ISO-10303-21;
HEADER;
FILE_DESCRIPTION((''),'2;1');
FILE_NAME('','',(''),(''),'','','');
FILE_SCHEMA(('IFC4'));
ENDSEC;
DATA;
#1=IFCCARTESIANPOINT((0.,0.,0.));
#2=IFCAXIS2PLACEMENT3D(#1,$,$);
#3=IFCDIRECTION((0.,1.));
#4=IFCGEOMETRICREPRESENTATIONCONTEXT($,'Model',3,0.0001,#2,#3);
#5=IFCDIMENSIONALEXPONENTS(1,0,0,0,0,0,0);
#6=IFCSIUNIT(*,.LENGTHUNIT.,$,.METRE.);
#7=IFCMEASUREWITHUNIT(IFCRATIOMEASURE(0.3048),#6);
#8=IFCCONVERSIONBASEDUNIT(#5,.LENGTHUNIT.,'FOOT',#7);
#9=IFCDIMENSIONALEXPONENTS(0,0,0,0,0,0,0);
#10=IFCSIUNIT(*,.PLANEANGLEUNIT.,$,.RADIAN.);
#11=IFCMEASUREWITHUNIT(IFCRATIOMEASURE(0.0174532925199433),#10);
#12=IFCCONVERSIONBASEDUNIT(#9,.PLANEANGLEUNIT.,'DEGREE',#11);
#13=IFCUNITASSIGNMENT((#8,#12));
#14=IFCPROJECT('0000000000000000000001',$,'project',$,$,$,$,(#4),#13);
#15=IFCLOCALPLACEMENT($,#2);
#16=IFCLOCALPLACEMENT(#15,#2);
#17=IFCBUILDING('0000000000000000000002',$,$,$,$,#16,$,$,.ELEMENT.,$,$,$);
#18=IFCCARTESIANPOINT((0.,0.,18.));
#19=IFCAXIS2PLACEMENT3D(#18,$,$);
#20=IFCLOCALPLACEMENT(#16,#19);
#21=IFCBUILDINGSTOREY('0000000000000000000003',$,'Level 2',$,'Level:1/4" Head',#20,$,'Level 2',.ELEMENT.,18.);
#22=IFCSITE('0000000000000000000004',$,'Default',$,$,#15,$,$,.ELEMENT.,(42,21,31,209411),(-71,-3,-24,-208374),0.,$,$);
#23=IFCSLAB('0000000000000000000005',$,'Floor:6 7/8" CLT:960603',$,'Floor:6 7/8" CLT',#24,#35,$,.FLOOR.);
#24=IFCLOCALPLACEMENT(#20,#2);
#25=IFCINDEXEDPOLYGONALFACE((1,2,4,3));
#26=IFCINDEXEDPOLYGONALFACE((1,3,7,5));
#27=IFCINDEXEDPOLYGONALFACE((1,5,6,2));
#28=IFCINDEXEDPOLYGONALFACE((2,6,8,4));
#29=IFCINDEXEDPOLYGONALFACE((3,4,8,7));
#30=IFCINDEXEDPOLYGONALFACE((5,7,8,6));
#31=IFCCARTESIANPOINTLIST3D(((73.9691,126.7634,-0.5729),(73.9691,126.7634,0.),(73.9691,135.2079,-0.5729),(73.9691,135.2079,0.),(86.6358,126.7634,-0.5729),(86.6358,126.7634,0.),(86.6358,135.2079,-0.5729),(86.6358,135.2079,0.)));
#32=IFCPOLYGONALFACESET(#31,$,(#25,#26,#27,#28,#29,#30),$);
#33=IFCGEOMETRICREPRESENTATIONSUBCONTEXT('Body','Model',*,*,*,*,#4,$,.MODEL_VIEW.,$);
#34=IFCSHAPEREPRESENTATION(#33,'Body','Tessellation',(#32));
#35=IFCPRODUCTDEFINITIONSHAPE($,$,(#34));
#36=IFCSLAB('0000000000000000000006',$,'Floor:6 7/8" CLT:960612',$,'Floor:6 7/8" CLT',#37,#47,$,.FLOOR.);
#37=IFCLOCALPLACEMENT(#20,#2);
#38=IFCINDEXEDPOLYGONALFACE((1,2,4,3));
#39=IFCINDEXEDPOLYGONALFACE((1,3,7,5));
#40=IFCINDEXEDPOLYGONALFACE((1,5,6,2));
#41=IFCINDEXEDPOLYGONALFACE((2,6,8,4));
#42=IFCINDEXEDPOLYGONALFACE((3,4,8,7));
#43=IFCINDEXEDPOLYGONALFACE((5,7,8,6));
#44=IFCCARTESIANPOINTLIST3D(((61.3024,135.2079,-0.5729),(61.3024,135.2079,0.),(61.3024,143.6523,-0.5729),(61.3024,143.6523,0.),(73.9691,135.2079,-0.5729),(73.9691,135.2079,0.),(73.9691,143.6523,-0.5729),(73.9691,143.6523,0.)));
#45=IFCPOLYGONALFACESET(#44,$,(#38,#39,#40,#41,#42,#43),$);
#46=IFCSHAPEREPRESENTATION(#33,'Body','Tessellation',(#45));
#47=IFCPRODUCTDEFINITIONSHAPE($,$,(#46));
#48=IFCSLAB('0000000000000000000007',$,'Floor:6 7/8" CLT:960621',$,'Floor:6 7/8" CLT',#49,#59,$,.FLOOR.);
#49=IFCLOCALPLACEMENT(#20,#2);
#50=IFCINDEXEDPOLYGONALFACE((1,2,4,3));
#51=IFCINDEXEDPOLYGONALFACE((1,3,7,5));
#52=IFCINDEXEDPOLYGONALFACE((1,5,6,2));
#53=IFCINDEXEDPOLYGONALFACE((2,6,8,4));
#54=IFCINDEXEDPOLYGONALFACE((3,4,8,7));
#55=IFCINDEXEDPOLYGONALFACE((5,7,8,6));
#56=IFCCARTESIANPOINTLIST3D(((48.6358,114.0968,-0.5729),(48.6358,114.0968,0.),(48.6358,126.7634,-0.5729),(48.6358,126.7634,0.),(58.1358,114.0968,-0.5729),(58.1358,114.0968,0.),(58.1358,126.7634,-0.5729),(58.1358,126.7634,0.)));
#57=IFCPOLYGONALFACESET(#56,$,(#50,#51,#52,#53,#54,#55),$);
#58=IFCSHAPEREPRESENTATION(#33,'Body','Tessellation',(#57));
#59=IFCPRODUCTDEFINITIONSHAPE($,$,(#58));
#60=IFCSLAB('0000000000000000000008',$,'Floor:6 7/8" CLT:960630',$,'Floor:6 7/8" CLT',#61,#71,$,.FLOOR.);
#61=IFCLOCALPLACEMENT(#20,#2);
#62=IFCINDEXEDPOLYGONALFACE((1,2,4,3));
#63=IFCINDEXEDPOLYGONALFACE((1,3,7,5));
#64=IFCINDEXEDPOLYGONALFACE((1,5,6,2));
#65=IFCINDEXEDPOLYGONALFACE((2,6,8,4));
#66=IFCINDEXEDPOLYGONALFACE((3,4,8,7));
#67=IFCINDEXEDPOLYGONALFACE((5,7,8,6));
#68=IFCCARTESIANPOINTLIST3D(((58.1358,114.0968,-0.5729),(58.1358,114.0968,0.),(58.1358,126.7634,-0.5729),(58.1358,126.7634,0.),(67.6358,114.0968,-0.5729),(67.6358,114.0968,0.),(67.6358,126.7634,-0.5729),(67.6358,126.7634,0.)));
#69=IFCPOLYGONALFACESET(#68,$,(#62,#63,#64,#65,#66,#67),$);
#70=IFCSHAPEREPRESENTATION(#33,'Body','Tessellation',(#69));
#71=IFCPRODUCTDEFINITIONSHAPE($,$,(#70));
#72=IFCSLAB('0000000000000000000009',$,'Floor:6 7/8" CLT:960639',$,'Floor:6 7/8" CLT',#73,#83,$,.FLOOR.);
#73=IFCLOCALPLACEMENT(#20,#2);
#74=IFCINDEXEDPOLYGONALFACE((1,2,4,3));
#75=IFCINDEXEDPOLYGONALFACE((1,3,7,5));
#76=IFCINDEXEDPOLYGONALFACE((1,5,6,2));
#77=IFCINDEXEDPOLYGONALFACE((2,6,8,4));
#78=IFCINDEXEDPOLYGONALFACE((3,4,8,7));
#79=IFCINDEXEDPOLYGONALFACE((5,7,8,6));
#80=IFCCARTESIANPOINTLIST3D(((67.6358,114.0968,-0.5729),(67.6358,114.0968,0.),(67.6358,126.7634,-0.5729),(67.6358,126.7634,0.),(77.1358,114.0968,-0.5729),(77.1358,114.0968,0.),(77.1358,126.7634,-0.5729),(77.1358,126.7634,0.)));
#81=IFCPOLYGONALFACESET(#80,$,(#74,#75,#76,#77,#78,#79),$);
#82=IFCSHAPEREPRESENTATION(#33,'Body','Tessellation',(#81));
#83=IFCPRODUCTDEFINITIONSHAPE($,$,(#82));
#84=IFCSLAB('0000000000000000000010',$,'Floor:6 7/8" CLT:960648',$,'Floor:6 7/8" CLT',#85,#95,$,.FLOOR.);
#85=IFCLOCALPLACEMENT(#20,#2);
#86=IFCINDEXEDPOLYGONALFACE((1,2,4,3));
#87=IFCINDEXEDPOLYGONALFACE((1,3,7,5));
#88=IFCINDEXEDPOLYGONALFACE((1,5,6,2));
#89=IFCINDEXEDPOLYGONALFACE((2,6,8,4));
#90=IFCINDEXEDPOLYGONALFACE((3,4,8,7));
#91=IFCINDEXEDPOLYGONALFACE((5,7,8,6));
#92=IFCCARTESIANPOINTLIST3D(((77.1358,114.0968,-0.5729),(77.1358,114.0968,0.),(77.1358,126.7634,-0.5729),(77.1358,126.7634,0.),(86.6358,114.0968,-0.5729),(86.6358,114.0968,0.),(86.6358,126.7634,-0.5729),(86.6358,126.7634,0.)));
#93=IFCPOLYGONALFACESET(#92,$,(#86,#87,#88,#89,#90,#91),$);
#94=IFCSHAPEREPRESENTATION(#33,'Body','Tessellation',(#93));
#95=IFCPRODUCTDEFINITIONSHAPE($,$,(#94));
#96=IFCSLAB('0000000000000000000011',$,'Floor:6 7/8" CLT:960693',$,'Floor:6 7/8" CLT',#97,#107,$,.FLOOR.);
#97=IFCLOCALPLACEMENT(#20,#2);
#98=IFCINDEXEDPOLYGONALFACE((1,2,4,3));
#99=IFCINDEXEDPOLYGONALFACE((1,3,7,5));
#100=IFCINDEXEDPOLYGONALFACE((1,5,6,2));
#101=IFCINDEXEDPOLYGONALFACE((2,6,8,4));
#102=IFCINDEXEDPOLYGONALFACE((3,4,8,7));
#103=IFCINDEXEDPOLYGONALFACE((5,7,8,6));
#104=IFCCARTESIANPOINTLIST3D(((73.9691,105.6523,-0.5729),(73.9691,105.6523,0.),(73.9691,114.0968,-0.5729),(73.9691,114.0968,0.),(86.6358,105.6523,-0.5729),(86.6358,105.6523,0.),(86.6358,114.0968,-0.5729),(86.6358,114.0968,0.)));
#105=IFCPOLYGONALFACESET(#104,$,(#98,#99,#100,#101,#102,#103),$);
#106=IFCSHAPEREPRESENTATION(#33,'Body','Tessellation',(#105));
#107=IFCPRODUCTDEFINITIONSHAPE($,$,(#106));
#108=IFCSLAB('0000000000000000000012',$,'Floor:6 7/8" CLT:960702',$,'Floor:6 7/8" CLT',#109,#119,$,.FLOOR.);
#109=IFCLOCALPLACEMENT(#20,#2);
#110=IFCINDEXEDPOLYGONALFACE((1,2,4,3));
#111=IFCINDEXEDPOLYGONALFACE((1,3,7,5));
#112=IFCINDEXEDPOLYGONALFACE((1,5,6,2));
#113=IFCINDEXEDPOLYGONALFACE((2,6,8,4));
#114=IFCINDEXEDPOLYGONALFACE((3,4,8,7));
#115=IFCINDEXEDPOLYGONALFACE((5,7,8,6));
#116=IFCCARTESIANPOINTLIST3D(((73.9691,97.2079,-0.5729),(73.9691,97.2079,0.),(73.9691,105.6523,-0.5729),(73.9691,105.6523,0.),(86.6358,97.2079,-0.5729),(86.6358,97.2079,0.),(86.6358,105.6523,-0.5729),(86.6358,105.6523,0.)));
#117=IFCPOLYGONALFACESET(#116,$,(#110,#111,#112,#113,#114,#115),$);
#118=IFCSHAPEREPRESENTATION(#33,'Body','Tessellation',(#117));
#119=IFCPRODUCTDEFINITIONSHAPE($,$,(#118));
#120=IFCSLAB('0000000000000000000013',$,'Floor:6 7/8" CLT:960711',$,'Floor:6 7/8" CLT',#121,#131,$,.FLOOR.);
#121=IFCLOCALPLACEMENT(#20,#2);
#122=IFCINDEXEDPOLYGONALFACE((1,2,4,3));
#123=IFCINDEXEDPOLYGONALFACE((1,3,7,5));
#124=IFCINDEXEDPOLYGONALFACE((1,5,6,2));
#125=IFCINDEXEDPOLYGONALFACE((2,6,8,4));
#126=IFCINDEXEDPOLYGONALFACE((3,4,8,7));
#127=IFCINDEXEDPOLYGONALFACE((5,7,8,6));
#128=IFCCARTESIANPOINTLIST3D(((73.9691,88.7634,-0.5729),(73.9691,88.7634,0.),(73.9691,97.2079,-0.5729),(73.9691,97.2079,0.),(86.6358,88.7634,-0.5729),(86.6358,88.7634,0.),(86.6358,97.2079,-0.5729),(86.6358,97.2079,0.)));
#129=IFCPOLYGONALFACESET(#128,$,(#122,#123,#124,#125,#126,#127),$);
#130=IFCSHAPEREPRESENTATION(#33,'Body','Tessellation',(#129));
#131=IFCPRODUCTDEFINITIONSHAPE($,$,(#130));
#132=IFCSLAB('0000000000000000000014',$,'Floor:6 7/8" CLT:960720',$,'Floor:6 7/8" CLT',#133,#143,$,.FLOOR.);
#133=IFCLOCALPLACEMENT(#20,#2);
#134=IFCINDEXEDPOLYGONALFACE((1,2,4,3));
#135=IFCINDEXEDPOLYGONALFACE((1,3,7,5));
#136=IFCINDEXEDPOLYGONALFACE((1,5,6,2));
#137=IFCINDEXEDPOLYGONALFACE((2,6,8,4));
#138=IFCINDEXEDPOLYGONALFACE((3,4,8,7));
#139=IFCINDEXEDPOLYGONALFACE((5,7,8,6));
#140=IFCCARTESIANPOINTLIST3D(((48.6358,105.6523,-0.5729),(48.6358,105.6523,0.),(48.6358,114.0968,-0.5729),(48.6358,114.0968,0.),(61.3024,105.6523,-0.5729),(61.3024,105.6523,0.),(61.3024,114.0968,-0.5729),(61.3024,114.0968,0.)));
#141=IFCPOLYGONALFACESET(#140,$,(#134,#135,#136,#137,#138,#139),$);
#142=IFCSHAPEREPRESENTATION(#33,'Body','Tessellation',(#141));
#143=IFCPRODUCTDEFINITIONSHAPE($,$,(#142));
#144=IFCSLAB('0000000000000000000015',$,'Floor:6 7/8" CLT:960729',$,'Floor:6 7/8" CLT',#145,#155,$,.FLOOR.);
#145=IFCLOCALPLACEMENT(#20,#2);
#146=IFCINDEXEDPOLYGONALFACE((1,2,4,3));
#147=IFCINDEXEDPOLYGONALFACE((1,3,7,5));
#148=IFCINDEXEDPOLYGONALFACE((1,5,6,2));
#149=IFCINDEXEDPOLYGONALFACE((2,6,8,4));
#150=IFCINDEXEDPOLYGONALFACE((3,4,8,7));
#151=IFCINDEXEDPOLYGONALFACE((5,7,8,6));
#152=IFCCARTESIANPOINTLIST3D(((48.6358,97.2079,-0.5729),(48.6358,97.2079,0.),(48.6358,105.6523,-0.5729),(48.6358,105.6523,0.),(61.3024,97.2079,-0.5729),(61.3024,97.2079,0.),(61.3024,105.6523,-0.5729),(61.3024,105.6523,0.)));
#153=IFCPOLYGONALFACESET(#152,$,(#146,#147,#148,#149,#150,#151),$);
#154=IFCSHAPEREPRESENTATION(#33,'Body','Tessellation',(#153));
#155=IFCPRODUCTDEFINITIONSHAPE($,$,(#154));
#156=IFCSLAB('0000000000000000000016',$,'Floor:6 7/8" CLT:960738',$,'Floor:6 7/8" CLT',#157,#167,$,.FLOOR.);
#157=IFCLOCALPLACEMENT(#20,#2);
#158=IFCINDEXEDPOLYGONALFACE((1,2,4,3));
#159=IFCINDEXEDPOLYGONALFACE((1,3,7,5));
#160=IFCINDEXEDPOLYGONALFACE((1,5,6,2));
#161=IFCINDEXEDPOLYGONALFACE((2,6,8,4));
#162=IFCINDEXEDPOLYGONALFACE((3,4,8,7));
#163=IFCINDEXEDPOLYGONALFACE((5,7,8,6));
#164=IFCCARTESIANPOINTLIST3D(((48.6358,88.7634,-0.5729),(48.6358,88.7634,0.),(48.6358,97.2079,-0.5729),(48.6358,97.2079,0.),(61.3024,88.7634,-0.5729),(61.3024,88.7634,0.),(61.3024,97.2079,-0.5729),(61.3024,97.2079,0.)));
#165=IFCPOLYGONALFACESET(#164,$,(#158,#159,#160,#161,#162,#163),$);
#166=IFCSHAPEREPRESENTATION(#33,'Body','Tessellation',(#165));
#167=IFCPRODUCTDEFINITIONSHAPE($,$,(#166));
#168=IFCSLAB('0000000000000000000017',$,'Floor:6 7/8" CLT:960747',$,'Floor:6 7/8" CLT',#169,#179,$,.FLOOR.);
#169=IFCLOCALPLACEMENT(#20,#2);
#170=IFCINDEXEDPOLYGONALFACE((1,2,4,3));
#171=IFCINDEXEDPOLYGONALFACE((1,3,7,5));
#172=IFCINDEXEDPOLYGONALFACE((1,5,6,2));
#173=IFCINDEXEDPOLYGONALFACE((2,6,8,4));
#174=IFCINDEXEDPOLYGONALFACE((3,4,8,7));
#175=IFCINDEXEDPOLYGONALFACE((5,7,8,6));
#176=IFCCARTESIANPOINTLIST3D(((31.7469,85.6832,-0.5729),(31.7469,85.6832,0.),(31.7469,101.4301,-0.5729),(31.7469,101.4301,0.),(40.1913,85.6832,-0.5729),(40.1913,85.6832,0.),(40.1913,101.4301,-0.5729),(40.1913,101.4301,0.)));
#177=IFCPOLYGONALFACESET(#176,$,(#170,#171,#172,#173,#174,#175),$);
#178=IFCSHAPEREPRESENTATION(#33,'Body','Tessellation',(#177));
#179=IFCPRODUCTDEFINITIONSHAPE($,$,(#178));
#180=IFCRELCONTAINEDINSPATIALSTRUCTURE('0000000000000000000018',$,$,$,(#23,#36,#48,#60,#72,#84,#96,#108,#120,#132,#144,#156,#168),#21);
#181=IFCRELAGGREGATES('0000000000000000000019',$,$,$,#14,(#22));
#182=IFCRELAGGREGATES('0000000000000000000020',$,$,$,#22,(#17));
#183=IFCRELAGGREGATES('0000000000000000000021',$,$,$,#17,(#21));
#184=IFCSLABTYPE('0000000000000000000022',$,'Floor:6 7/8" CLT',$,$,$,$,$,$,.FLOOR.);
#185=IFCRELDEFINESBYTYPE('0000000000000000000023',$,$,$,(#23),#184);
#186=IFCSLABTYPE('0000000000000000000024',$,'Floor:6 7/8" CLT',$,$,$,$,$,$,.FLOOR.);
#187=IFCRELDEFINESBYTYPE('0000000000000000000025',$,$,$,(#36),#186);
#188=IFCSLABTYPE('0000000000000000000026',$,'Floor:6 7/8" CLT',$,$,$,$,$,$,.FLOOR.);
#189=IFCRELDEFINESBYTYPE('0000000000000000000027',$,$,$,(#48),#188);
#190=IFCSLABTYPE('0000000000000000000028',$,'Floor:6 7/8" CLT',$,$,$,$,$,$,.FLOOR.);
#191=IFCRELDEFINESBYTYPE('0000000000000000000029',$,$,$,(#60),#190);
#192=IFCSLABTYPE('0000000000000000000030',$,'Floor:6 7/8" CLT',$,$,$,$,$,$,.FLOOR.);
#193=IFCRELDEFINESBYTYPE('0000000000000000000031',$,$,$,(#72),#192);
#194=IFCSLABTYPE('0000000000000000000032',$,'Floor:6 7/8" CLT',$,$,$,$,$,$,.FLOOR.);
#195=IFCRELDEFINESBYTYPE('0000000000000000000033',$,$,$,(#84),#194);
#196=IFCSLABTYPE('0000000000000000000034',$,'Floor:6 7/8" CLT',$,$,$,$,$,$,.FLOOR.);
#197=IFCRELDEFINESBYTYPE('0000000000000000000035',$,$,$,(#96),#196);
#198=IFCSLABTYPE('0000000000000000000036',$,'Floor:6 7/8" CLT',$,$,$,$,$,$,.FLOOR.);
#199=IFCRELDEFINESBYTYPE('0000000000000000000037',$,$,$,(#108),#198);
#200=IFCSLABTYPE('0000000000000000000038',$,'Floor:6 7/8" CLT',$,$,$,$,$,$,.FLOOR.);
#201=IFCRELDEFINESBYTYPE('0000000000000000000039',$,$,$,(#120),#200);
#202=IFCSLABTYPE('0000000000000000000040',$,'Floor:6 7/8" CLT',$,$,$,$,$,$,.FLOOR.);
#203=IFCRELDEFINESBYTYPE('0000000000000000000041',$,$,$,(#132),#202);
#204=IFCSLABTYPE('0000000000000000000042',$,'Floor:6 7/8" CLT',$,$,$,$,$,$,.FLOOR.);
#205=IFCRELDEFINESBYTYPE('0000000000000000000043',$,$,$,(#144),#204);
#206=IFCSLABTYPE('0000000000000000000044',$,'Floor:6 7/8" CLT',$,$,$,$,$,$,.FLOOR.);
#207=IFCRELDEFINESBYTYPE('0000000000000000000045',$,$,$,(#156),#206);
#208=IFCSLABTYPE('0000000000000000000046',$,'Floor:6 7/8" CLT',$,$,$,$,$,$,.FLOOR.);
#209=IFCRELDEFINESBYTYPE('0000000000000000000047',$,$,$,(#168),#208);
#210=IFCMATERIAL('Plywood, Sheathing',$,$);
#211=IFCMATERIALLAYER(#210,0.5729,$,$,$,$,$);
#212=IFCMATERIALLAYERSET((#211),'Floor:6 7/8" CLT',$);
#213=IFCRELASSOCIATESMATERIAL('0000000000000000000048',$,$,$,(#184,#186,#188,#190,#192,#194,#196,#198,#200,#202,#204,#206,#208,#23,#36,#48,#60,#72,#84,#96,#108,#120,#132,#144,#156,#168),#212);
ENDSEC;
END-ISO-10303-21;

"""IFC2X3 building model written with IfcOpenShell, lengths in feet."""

from ifc_helpers import new_model, entity, si_unit, converted_unit, direction, frame, frame_2d, origin, place, context, subcontext, project, spatial, rectangle, extrude, material, layer, layer_set, layer_usage, type_object, element, save


model = new_model("IFC2X3")

# Units and contexts
model_context = context("Model", 3, precision=0.0001, world=origin(), true_north=direction((0.0, 1.0)))
body_context = subcontext(model_context, "Body", "Model", "MODEL_VIEW")
ifc_project = project(units=[converted_unit("LENGTHUNIT", "FOOT", entity("IfcRatioMeasure", 0.3048), si_unit("LENGTHUNIT", "METRE"), dimensions=[1, 0, 0, 0, 0, 0, 0]), converted_unit("PLANEANGLEUNIT", "DEGREE", entity("IfcRatioMeasure", 0.0174532925199433), si_unit("PLANEANGLEUNIT", "RADIAN"), dimensions=[0, 0, 0, 0, 0, 0, 0])], contexts=[model_context])

# Site, building, storey
site_placement = place(None, origin())
site = spatial("IfcSite", under=ifc_project, at=site_placement, Name="Default", CompositionType="ELEMENT", RefLatitude=(42, 21, 31, 209411), RefLongitude=(-71, -3, -24, -208374), RefElevation=0.0)
building_placement = place(site_placement, origin())
building = spatial("IfcBuilding", under=site, at=building_placement, CompositionType="ELEMENT")
storey_placement = place(building_placement, frame((0.0, 0.0, 18.0)))
storey = spatial("IfcBuildingStorey", under=building, at=storey_placement, Name="Level 2", ObjectType="Level:1/4\" Head", LongName="Level 2", CompositionType="ELEMENT", Elevation=18.0)

# Slabs
ifc_material = material(Name="Plywood, Sheathing")
ifc_layer = layer(ifc_material, 0.5729)
ifc_layer_set = layer_set([ifc_layer], Name="Floor:6 7/8\" CLT")
ifc_layer_usage_1 = layer_usage(ifc_layer_set, "AXIS3", "POSITIVE", 0.0)
slab_type_1 = type_object("IfcSlabType", Name="Floor:6 7/8\" CLT", PredefinedType="FLOOR", material=ifc_layer_set)
slab_1_placement = place(storey_placement, origin())
element("IfcSlab", 1, at=slab_1_placement, inside=storey, type_object=slab_type_1, material=ifc_layer_usage_1, Name="Floor:6 7/8\" CLT:960603", ObjectType="Floor:6 7/8\" CLT", PredefinedType="FLOOR", context=body_context, shape_type="SweptSolid", body=[
    extrude(rectangle(XDim=8.4444, YDim=12.6667, at=frame_2d((0.0, 0.0), x_axis=(1.0, 0.0))), frame((80.3024, 130.9856, 0.0), z_axis=(0.0, 0.0, -1.0), x_axis=(0.0, 1.0, 0.0)), (0.0, 0.0, 1.0), 0.5729),
])
ifc_layer_usage_2 = layer_usage(ifc_layer_set, "AXIS3", "POSITIVE", 0.0)
slab_type_2 = type_object("IfcSlabType", Name="Floor:6 7/8\" CLT", PredefinedType="FLOOR", material=ifc_layer_set)
slab_2_placement = place(storey_placement, origin())
element("IfcSlab", 2, at=slab_2_placement, inside=storey, type_object=slab_type_2, material=ifc_layer_usage_2, Name="Floor:6 7/8\" CLT:960612", ObjectType="Floor:6 7/8\" CLT", PredefinedType="FLOOR", context=body_context, shape_type="SweptSolid", body=[
    extrude(rectangle(XDim=8.4444, YDim=12.6667, at=frame_2d((0.0, 0.0), x_axis=(1.0, 0.0))), frame((67.6358, 139.4301, 0.0), z_axis=(0.0, 0.0, -1.0), x_axis=(0.0, 1.0, 0.0)), (0.0, 0.0, 1.0), 0.5729),
])
ifc_layer_usage_3 = layer_usage(ifc_layer_set, "AXIS3", "POSITIVE", 0.0)
slab_type_3 = type_object("IfcSlabType", Name="Floor:6 7/8\" CLT", PredefinedType="FLOOR", material=ifc_layer_set)
slab_3_placement = place(storey_placement, origin())
element("IfcSlab", 3, at=slab_3_placement, inside=storey, type_object=slab_type_3, material=ifc_layer_usage_3, Name="Floor:6 7/8\" CLT:960621", ObjectType="Floor:6 7/8\" CLT", PredefinedType="FLOOR", context=body_context, shape_type="SweptSolid", body=[
    extrude(rectangle(XDim=12.6667, YDim=9.5, at=frame_2d((0.0, 0.0), x_axis=(1.0, 0.0))), frame((53.3858, 120.4301, 0.0), z_axis=(0.0, 0.0, -1.0), x_axis=(0.0, 1.0, 0.0)), (0.0, 0.0, 1.0), 0.5729),
])
ifc_layer_usage_4 = layer_usage(ifc_layer_set, "AXIS3", "POSITIVE", 0.0)
slab_type_4 = type_object("IfcSlabType", Name="Floor:6 7/8\" CLT", PredefinedType="FLOOR", material=ifc_layer_set)
slab_4_placement = place(storey_placement, origin())
element("IfcSlab", 4, at=slab_4_placement, inside=storey, type_object=slab_type_4, material=ifc_layer_usage_4, Name="Floor:6 7/8\" CLT:960630", ObjectType="Floor:6 7/8\" CLT", PredefinedType="FLOOR", context=body_context, shape_type="SweptSolid", body=[
    extrude(rectangle(XDim=12.6667, YDim=9.5, at=frame_2d((0.0, 0.0), x_axis=(1.0, 0.0))), frame((62.8858, 120.4301, 0.0), z_axis=(0.0, 0.0, -1.0), x_axis=(0.0, 1.0, 0.0)), (0.0, 0.0, 1.0), 0.5729),
])
ifc_layer_usage_5 = layer_usage(ifc_layer_set, "AXIS3", "POSITIVE", 0.0)
slab_type_5 = type_object("IfcSlabType", Name="Floor:6 7/8\" CLT", PredefinedType="FLOOR", material=ifc_layer_set)
slab_5_placement = place(storey_placement, origin())
element("IfcSlab", 5, at=slab_5_placement, inside=storey, type_object=slab_type_5, material=ifc_layer_usage_5, Name="Floor:6 7/8\" CLT:960639", ObjectType="Floor:6 7/8\" CLT", PredefinedType="FLOOR", context=body_context, shape_type="SweptSolid", body=[
    extrude(rectangle(XDim=12.6667, YDim=9.5, at=frame_2d((0.0, 0.0), x_axis=(1.0, 0.0))), frame((72.3858, 120.4301, 0.0), z_axis=(0.0, 0.0, -1.0), x_axis=(0.0, 1.0, 0.0)), (0.0, 0.0, 1.0), 0.5729),
])
ifc_layer_usage_6 = layer_usage(ifc_layer_set, "AXIS3", "POSITIVE", 0.0)
slab_type_6 = type_object("IfcSlabType", Name="Floor:6 7/8\" CLT", PredefinedType="FLOOR", material=ifc_layer_set)
slab_6_placement = place(storey_placement, origin())
element("IfcSlab", 6, at=slab_6_placement, inside=storey, type_object=slab_type_6, material=ifc_layer_usage_6, Name="Floor:6 7/8\" CLT:960648", ObjectType="Floor:6 7/8\" CLT", PredefinedType="FLOOR", context=body_context, shape_type="SweptSolid", body=[
    extrude(rectangle(XDim=12.6667, YDim=9.5, at=frame_2d((0.0, 0.0), x_axis=(1.0, 0.0))), frame((81.8858, 120.4301, 0.0), z_axis=(0.0, 0.0, -1.0), x_axis=(0.0, 1.0, 0.0)), (0.0, 0.0, 1.0), 0.5729),
])
ifc_layer_usage_7 = layer_usage(ifc_layer_set, "AXIS3", "POSITIVE", 0.0)
slab_type_7 = type_object("IfcSlabType", Name="Floor:6 7/8\" CLT", PredefinedType="FLOOR", material=ifc_layer_set)
slab_7_placement = place(storey_placement, origin())
element("IfcSlab", 7, at=slab_7_placement, inside=storey, type_object=slab_type_7, material=ifc_layer_usage_7, Name="Floor:6 7/8\" CLT:960693", ObjectType="Floor:6 7/8\" CLT", PredefinedType="FLOOR", context=body_context, shape_type="SweptSolid", body=[
    extrude(rectangle(XDim=8.4444, YDim=12.6667, at=frame_2d((0.0, 0.0), x_axis=(1.0, 0.0))), frame((80.3024, 109.8745, 0.0), z_axis=(0.0, 0.0, -1.0), x_axis=(0.0, 1.0, 0.0)), (0.0, 0.0, 1.0), 0.5729),
])
ifc_layer_usage_8 = layer_usage(ifc_layer_set, "AXIS3", "POSITIVE", 0.0)
slab_type_8 = type_object("IfcSlabType", Name="Floor:6 7/8\" CLT", PredefinedType="FLOOR", material=ifc_layer_set)
slab_8_placement = place(storey_placement, origin())
element("IfcSlab", 8, at=slab_8_placement, inside=storey, type_object=slab_type_8, material=ifc_layer_usage_8, Name="Floor:6 7/8\" CLT:960702", ObjectType="Floor:6 7/8\" CLT", PredefinedType="FLOOR", context=body_context, shape_type="SweptSolid", body=[
    extrude(rectangle(XDim=8.4444, YDim=12.6667, at=frame_2d((0.0, 0.0), x_axis=(1.0, 0.0))), frame((80.3024, 101.4301, 0.0), z_axis=(0.0, 0.0, -1.0), x_axis=(0.0, 1.0, 0.0)), (0.0, 0.0, 1.0), 0.5729),
])
ifc_layer_usage_9 = layer_usage(ifc_layer_set, "AXIS3", "POSITIVE", 0.0)
slab_type_9 = type_object("IfcSlabType", Name="Floor:6 7/8\" CLT", PredefinedType="FLOOR", material=ifc_layer_set)
slab_9_placement = place(storey_placement, origin())
element("IfcSlab", 9, at=slab_9_placement, inside=storey, type_object=slab_type_9, material=ifc_layer_usage_9, Name="Floor:6 7/8\" CLT:960711", ObjectType="Floor:6 7/8\" CLT", PredefinedType="FLOOR", context=body_context, shape_type="SweptSolid", body=[
    extrude(rectangle(XDim=8.4444, YDim=12.6667, at=frame_2d((0.0, 0.0), x_axis=(1.0, 0.0))), frame((80.3024, 92.9856, 0.0), z_axis=(0.0, 0.0, -1.0), x_axis=(0.0, 1.0, 0.0)), (0.0, 0.0, 1.0), 0.5729),
])
ifc_layer_usage_10 = layer_usage(ifc_layer_set, "AXIS3", "POSITIVE", 0.0)
slab_type_10 = type_object("IfcSlabType", Name="Floor:6 7/8\" CLT", PredefinedType="FLOOR", material=ifc_layer_set)
slab_10_placement = place(storey_placement, origin())
element("IfcSlab", 10, at=slab_10_placement, inside=storey, type_object=slab_type_10, material=ifc_layer_usage_10, Name="Floor:6 7/8\" CLT:960720", ObjectType="Floor:6 7/8\" CLT", PredefinedType="FLOOR", context=body_context, shape_type="SweptSolid", body=[
    extrude(rectangle(XDim=8.4444, YDim=12.6667, at=frame_2d((0.0, 0.0), x_axis=(1.0, 0.0))), frame((54.9691, 109.8745, 0.0), z_axis=(0.0, 0.0, -1.0), x_axis=(0.0, 1.0, 0.0)), (0.0, 0.0, 1.0), 0.5729),
])
ifc_layer_usage_11 = layer_usage(ifc_layer_set, "AXIS3", "POSITIVE", 0.0)
slab_type_11 = type_object("IfcSlabType", Name="Floor:6 7/8\" CLT", PredefinedType="FLOOR", material=ifc_layer_set)
slab_11_placement = place(storey_placement, origin())
element("IfcSlab", 11, at=slab_11_placement, inside=storey, type_object=slab_type_11, material=ifc_layer_usage_11, Name="Floor:6 7/8\" CLT:960729", ObjectType="Floor:6 7/8\" CLT", PredefinedType="FLOOR", context=body_context, shape_type="SweptSolid", body=[
    extrude(rectangle(XDim=8.4444, YDim=12.6667, at=frame_2d((0.0, 0.0), x_axis=(1.0, 0.0))), frame((54.9691, 101.4301, 0.0), z_axis=(0.0, 0.0, -1.0), x_axis=(0.0, 1.0, 0.0)), (0.0, 0.0, 1.0), 0.5729),
])
ifc_layer_usage_12 = layer_usage(ifc_layer_set, "AXIS3", "POSITIVE", 0.0)
slab_type_12 = type_object("IfcSlabType", Name="Floor:6 7/8\" CLT", PredefinedType="FLOOR", material=ifc_layer_set)
slab_12_placement = place(storey_placement, origin())
element("IfcSlab", 12, at=slab_12_placement, inside=storey, type_object=slab_type_12, material=ifc_layer_usage_12, Name="Floor:6 7/8\" CLT:960738", ObjectType="Floor:6 7/8\" CLT", PredefinedType="FLOOR", context=body_context, shape_type="SweptSolid", body=[
    extrude(rectangle(XDim=8.4444, YDim=12.6667, at=frame_2d((0.0, 0.0), x_axis=(1.0, 0.0))), frame((54.9691, 92.9856, 0.0), z_axis=(0.0, 0.0, -1.0), x_axis=(0.0, 1.0, 0.0)), (0.0, 0.0, 1.0), 0.5729),
])
ifc_layer_usage_13 = layer_usage(ifc_layer_set, "AXIS3", "POSITIVE", 0.0)
slab_type_13 = type_object("IfcSlabType", Name="Floor:6 7/8\" CLT", PredefinedType="FLOOR", material=ifc_layer_set)
slab_13_placement = place(storey_placement, origin())
element("IfcSlab", 13, at=slab_13_placement, inside=storey, type_object=slab_type_13, material=ifc_layer_usage_13, Name="Floor:6 7/8\" CLT:960747", ObjectType="Floor:6 7/8\" CLT", PredefinedType="FLOOR", context=body_context, shape_type="SweptSolid", body=[
    extrude(rectangle(XDim=15.7469, YDim=8.4444, at=frame_2d((0.0, 0.0), x_axis=(1.0, 0.0))), frame((35.9691, 93.5566, 0.0), z_axis=(0.0, 0.0, -1.0), x_axis=(0.0, 1.0, 0.0)), (0.0, 0.0, 1.0), 0.5729),
])

save(model, "model.ifc")
